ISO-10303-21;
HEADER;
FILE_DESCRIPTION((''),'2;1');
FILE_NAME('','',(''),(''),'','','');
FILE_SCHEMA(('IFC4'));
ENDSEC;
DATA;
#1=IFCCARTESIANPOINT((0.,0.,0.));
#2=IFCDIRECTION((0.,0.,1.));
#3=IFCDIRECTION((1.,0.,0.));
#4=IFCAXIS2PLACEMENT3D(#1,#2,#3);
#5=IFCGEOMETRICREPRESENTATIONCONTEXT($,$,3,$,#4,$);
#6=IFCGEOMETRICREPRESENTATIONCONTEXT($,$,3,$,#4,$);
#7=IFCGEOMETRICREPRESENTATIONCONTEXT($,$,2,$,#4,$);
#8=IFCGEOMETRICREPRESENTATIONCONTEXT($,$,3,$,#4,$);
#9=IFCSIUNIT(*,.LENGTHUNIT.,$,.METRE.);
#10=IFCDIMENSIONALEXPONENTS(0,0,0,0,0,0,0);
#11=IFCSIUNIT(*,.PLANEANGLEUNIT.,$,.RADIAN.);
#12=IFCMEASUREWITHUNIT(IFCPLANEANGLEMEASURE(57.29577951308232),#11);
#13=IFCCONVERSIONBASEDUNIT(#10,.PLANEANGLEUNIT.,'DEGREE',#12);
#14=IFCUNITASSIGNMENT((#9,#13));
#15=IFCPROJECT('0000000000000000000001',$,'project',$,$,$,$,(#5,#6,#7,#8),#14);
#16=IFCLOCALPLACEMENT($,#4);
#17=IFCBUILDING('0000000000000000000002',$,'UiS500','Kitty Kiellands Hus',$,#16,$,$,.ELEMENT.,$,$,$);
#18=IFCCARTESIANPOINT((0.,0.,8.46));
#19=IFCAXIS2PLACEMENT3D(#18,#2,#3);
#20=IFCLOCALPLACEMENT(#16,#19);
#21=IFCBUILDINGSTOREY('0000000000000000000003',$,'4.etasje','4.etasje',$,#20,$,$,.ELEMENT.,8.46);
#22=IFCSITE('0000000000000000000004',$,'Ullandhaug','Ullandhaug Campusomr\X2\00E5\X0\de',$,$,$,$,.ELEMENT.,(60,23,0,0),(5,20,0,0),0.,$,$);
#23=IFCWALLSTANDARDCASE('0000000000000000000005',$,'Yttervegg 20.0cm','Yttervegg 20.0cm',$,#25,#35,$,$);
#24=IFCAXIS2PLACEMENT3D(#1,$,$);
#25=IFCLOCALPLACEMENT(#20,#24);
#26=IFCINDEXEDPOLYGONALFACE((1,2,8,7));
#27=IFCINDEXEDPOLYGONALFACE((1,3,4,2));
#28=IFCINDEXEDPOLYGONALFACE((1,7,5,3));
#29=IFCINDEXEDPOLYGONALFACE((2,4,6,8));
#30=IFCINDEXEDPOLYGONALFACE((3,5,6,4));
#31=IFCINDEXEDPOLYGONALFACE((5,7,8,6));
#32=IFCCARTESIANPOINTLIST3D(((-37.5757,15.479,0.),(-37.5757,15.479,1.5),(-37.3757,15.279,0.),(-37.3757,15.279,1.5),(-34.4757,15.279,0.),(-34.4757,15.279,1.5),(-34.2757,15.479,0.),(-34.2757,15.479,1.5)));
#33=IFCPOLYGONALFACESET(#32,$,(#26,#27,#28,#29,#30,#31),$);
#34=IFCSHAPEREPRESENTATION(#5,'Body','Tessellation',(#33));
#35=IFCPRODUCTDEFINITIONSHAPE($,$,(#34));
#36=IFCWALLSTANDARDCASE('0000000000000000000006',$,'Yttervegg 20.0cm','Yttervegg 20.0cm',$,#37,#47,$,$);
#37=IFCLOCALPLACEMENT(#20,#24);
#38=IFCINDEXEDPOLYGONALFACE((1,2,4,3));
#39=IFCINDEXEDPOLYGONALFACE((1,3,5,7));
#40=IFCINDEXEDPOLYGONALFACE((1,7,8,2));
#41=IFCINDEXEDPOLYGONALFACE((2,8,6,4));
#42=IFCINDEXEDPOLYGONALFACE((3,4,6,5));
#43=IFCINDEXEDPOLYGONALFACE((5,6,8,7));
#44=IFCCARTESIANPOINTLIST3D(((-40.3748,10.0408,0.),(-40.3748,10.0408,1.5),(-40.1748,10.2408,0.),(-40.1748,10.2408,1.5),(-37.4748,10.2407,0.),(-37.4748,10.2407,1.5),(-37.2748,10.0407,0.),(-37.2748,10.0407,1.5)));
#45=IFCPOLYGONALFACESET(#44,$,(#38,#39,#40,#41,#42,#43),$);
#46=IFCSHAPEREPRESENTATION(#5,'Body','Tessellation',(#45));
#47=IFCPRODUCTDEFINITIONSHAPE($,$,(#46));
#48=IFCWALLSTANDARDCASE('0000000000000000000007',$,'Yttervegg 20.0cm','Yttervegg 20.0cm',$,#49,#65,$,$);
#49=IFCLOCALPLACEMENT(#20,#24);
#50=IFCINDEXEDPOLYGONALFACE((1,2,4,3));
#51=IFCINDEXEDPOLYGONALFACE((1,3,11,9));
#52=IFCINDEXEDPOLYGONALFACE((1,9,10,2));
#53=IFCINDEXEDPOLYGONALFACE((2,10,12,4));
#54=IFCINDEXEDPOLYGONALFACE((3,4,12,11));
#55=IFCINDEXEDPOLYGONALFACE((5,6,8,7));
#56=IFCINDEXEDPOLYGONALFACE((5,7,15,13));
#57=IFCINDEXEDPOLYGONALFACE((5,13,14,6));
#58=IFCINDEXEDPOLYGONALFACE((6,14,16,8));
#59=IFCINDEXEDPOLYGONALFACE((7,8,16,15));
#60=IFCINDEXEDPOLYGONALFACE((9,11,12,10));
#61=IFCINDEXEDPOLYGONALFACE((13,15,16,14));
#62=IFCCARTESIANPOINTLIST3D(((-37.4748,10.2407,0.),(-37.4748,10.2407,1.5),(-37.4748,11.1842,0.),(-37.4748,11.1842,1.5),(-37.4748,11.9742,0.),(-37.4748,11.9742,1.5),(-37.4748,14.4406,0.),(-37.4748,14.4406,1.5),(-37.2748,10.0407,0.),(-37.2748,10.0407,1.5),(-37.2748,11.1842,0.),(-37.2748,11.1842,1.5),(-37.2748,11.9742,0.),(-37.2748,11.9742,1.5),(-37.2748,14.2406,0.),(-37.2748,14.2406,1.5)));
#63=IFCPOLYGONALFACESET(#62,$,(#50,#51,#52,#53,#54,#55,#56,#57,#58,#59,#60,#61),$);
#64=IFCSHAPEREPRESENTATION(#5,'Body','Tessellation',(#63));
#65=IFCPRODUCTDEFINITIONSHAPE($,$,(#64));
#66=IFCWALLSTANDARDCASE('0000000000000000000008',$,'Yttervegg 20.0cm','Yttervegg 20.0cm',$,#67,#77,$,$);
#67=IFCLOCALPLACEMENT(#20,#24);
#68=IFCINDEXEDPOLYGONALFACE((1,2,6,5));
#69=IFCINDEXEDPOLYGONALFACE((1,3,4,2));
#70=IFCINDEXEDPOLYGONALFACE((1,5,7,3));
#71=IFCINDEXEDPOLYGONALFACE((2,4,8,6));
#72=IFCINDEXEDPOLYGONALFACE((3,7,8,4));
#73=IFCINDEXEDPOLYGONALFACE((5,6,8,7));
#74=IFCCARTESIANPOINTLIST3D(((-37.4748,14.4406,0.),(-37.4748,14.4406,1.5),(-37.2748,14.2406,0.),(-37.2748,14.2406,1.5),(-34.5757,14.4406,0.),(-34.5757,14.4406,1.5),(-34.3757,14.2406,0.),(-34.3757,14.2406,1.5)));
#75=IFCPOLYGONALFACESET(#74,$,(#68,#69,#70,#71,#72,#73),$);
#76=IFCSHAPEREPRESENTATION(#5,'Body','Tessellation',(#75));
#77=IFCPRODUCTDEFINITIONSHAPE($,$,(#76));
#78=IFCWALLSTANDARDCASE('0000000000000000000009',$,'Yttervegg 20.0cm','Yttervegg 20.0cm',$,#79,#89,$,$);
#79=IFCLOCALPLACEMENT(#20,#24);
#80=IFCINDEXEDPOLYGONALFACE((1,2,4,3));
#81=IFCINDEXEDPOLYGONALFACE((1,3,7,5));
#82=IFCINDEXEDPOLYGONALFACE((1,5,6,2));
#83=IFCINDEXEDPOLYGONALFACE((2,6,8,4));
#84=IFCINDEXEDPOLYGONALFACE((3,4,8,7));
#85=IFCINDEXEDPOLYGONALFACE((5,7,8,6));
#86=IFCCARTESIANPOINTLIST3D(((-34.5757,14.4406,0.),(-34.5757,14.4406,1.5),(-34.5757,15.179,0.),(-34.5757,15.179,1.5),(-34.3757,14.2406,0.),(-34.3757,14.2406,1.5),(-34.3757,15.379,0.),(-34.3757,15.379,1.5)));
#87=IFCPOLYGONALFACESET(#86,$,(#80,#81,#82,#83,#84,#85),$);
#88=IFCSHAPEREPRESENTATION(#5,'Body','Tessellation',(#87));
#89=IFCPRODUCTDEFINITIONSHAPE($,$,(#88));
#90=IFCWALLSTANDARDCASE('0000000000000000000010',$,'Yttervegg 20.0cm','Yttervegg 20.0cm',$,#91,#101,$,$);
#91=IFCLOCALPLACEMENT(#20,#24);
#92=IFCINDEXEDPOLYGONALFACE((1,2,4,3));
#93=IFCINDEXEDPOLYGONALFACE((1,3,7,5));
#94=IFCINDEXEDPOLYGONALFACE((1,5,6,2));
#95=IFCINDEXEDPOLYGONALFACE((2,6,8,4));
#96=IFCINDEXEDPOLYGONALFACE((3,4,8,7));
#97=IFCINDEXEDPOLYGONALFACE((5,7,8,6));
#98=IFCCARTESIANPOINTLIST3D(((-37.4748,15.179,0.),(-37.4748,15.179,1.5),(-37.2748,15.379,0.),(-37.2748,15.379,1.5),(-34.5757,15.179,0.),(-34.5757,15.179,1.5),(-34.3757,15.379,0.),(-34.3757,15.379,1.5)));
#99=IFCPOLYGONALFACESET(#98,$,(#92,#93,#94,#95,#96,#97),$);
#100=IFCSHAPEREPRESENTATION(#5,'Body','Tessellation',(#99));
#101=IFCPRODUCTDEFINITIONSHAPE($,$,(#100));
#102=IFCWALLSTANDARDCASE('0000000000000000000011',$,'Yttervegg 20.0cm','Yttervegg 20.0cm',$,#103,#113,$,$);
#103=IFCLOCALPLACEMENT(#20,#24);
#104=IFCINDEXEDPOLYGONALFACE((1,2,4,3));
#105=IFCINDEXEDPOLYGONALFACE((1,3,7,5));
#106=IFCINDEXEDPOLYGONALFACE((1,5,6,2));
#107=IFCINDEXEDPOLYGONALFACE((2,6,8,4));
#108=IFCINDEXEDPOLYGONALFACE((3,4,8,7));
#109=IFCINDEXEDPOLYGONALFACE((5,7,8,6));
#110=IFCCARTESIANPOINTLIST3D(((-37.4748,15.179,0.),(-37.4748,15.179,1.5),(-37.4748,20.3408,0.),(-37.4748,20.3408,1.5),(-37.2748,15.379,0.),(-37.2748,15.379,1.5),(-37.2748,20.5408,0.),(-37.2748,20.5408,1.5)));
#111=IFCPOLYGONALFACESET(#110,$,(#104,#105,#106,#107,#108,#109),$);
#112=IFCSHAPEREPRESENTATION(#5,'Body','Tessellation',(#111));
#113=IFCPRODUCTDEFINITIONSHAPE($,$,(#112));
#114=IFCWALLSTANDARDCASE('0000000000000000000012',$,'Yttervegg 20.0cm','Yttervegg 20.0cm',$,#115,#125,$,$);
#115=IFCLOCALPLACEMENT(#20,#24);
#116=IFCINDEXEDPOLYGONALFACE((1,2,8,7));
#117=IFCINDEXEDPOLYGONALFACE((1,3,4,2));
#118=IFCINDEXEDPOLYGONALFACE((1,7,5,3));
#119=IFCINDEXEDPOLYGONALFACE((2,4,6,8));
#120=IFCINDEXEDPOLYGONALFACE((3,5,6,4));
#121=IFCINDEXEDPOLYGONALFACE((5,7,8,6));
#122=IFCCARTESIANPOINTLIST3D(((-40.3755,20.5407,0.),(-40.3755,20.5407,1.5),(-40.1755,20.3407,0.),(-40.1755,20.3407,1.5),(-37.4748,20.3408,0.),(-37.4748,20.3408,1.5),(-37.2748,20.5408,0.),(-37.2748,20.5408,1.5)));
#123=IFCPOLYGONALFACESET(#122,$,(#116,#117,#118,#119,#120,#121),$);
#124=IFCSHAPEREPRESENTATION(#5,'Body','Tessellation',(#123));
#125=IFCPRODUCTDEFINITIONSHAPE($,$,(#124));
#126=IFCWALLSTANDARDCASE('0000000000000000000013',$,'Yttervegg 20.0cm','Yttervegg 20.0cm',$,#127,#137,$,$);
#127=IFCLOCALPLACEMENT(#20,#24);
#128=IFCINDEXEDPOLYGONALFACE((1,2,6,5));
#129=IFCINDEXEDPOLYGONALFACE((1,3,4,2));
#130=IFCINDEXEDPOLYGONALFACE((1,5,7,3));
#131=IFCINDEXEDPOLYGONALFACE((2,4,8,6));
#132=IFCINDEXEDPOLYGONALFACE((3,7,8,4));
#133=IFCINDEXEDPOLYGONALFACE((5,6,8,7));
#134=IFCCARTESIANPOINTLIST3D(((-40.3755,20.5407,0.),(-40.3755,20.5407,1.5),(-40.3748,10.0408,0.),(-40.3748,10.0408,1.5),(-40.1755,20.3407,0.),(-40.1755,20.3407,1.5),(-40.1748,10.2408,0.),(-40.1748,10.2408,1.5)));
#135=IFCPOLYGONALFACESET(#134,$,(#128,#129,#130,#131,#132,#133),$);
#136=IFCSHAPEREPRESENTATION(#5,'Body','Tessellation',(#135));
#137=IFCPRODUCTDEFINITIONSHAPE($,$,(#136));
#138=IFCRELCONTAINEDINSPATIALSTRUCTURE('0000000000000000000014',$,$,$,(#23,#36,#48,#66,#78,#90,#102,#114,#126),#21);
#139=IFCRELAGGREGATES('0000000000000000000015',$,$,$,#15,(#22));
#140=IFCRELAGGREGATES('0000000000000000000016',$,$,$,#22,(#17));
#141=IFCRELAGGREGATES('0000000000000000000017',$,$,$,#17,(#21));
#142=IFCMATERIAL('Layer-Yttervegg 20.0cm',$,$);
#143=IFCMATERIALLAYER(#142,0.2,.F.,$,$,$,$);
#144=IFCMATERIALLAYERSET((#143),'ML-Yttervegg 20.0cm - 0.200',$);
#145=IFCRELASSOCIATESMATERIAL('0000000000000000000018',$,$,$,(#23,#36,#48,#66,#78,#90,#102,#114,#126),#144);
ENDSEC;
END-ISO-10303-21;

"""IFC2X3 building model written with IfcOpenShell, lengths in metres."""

from ifc_helpers import new_model, entity, si_unit, converted_unit, frame, origin_with_axes, place, context, project, spatial, polyline, outline, extrude, material, layer, layer_set, layer_usage, element, save


model = new_model("IFC2X3")

# Units and contexts
context_of_model_1 = context(None, 3, world=origin_with_axes())
context_of_model_2 = context(None, 3, world=origin_with_axes())
context_of_model_3 = context(None, 2, world=origin_with_axes())
context_of_model_4 = context(None, 3, world=origin_with_axes())
ifc_project = project(units=[si_unit("LENGTHUNIT", "METRE"), converted_unit("PLANEANGLEUNIT", "DEGREE", entity("IfcPlaneAngleMeasure", 57.29577951308232), si_unit("PLANEANGLEUNIT", "RADIAN"), dimensions=[0, 0, 0, 0, 0, 0, 0])], contexts=[context_of_model_1, context_of_model_2, context_of_model_3, context_of_model_4])

# Site, building, storey
site = spatial("IfcSite", under=ifc_project, Name="Ullandhaug", Description="Ullandhaug Campusområde", CompositionType="ELEMENT", RefLatitude=(60, 23, 0, 0), RefLongitude=(5, 20, 0, 0), RefElevation=0.0)
building_placement = place(None, origin_with_axes())
building = spatial("IfcBuilding", under=site, at=building_placement, Name="UiS500", Description="Kitty Kiellands Hus", CompositionType="ELEMENT")
storey_placement = place(building_placement, frame((0.0, 0.0, 8.46), z_axis=(0.0, 0.0, 1.0), x_axis=(1.0, 0.0, 0.0)))
storey = spatial("IfcBuildingStorey", under=building, at=storey_placement, Name="4.etasje", Description="4.etasje", CompositionType="ELEMENT", Elevation=8.46)

# Walls
ifc_material_1 = material(Name="Layer-Yttervegg 20.0cm")
ifc_layer_1 = layer(ifc_material_1, 0.2, ventilated=False)
ifc_layer_set_1 = layer_set([ifc_layer_1], Name="ML-Yttervegg 20.0cm - 0.200")
ifc_layer_usage_1 = layer_usage(ifc_layer_set_1, "AXIS2", "POSITIVE", 0.0)
wall_1_placement = place(storey_placement, frame((-37.3757, 15.279, 0.0), z_axis=(0.0, 0.0, 1.0), x_axis=(1.0, 0.0, 0.0)))
element("IfcWallStandardCase", 1, at=wall_1_placement, inside=storey, material=ifc_layer_usage_1, Name="Yttervegg 20.0cm", Description="Yttervegg 20.0cm", context=context_of_model_1, shape_type="SweptSolid", body=[
    extrude(outline(polyline([(0.0, 0.0), (2.9, 0.0), (3.1, 0.2), (-0.2, 0.2), (0.0, 0.0)])), origin_with_axes(), (0.0, 0.0, 1.0), 1.5),
])
wall_2_placement = place(storey_placement, frame((-40.3748, 10.0408, 0.0), z_axis=(0.0, 0.0, 1.0), x_axis=(1.0, -0.000034, 0.0)))
element("IfcWallStandardCase", 2, at=wall_2_placement, inside=storey, material=ifc_layer_usage_1, Name="Yttervegg 20.0cm", Description="Yttervegg 20.0cm", context=context_of_model_1, shape_type="SweptSolid", body=[
    extrude(outline(polyline([(0.0, 0.0), (3.1, 0.0), (2.9, 0.2), (0.2, 0.2), (0.0, 0.0)])), frame((0.0, 0.0, 0.0), z_axis=(0.0, 0.0, 1.0), x_axis=(1.0, 0.0, 0.0)), (0.0, 0.0, 1.0), 1.5),
])

# Wall, opening
wall_3_placement = place(storey_placement, frame((-37.2748, 10.0407, 0.0), z_axis=(0.0, 0.0, 1.0), x_axis=(0.0, 1.0, 0.0)))
wall_3 = element("IfcWallStandardCase", 3, at=wall_3_placement, inside=storey, material=ifc_layer_usage_1, Name="Yttervegg 20.0cm", Description="Yttervegg 20.0cm", context=context_of_model_1, shape_type="SweptSolid", body=[
    extrude(outline(polyline([(0.0, 0.0), (4.1998, 0.0), (4.3998, 0.2), (0.2, 0.2), (0.0, 0.0)])), frame((0.0, 0.0, 0.0), z_axis=(0.0, 0.0, 1.0), x_axis=(1.0, 0.0, 0.0)), (0.0, 0.0, 1.0), 1.5),
])
opening_placement = place(wall_3_placement, frame((1.1434, 0.2, 0.0), z_axis=(0.0, 0.0, 1.0), x_axis=(1.0, 0.0, 0.0)))
element("IfcOpeningElement", 4, at=opening_placement, cuts=wall_3, context=context_of_model_1, shape_type="SweptSolid", body=[
    extrude(outline(polyline([(0.0, 0.0), (1.5, 0.0), (1.5, 0.79), (0.0, 0.79), (0.0, 0.0)])), frame((0.0, 0.0, 0.0), z_axis=(0.0, 1.0, 0.0), x_axis=(0.0, 0.0, 1.0)), (0.0, 0.0, -1.0), 0.2),
])

# Walls
wall_4_placement = place(storey_placement, frame((-37.2748, 14.2406, 0.0), z_axis=(0.0, 0.0, 1.0), x_axis=(1.0, 0.0, 0.0)))
element("IfcWallStandardCase", 5, at=wall_4_placement, inside=storey, material=ifc_layer_usage_1, Name="Yttervegg 20.0cm", Description="Yttervegg 20.0cm", context=context_of_model_1, shape_type="SweptSolid", body=[
    extrude(outline(polyline([(0.0, 0.0), (2.8991, 0.0), (2.6991, 0.2), (-0.2, 0.2), (0.0, 0.0)])), origin_with_axes(), (0.0, 0.0, 1.0), 1.5),
])
wall_5_placement = place(storey_placement, frame((-34.3757, 14.2406, 0.0), z_axis=(0.0, 0.0, 1.0), x_axis=(0.0, 1.0, 0.0)))
element("IfcWallStandardCase", 6, at=wall_5_placement, inside=storey, material=ifc_layer_usage_1, Name="Yttervegg 20.0cm", Description="Yttervegg 20.0cm", context=context_of_model_1, shape_type="SweptSolid", body=[
    extrude(outline(polyline([(0.0, 0.0), (1.1384, 0.0), (0.9384, 0.2), (0.2, 0.2), (0.0, 0.0)])), frame((0.0, 0.0, 0.0), z_axis=(0.0, 0.0, 1.0), x_axis=(1.0, 0.0, 0.0)), (0.0, 0.0, 1.0), 1.5),
])
wall_6_placement = place(storey_placement, frame((-34.3757, 15.379, 0.0), z_axis=(0.0, 0.0, 1.0), x_axis=(-1.0, 0.0, 0.0)))
element("IfcWallStandardCase", 7, at=wall_6_placement, inside=storey, material=ifc_layer_usage_1, Name="Yttervegg 20.0cm", Description="Yttervegg 20.0cm", context=context_of_model_1, shape_type="SweptSolid", body=[
    extrude(outline(polyline([(0.0, 0.0), (2.8991, 0.0), (3.0991, 0.2), (0.2, 0.2), (0.0, 0.0)])), frame((0.0, 0.0, 0.0), z_axis=(0.0, 0.0, 1.0), x_axis=(1.0, 0.0, 0.0)), (0.0, 0.0, 1.0), 1.5),
])
wall_7_placement = place(storey_placement, frame((-37.2748, 15.379, 0.0), z_axis=(0.0, 0.0, 1.0), x_axis=(0.0, 1.0, 0.0)))
element("IfcWallStandardCase", 8, at=wall_7_placement, inside=storey, material=ifc_layer_usage_1, Name="Yttervegg 20.0cm", Description="Yttervegg 20.0cm", context=context_of_model_1, shape_type="SweptSolid", body=[
    extrude(outline(polyline([(0.0, 0.0), (5.1619, 0.0), (4.9619, 0.2), (-0.2, 0.2), (0.0, 0.0)])), frame((0.0, 0.0, 0.0), z_axis=(0.0, 0.0, 1.0), x_axis=(1.0, 0.0, 0.0)), (0.0, 0.0, 1.0), 1.5),
])
wall_8_placement = place(storey_placement, frame((-37.2748, 20.5408, 0.0), z_axis=(0.0, 0.0, 1.0), x_axis=(-1.0, -0.00006, 0.0)))
element("IfcWallStandardCase", 9, at=wall_8_placement, inside=storey, material=ifc_layer_usage_1, Name="Yttervegg 20.0cm", Description="Yttervegg 20.0cm", context=context_of_model_1, shape_type="SweptSolid", body=[
    extrude(outline(polyline([(0.0, 0.0), (3.1006, 0.0), (2.9006, 0.2), (0.2, 0.2), (0.0, 0.0)])), frame((0.0, 0.0, 0.0), z_axis=(0.0, 0.0, 1.0), x_axis=(1.0, 0.0, 0.0)), (0.0, 0.0, 1.0), 1.5),
])
wall_9_placement = place(storey_placement, frame((-40.3755, 20.5407, 0.0), z_axis=(0.0, 0.0, 1.0), x_axis=(0.00006, -1.0, 0.0)))
element("IfcWallStandardCase", 10, at=wall_9_placement, inside=storey, material=ifc_layer_usage_1, Name="Yttervegg 20.0cm", Description="Yttervegg 20.0cm", context=context_of_model_1, shape_type="SweptSolid", body=[
    extrude(outline(polyline([(0.0, 0.0), (10.4998, 0.0), (10.2998, 0.2), (0.2, 0.2), (0.0, 0.0)])), frame((0.0, 0.0, 0.0), z_axis=(0.0, 0.0, 1.0), x_axis=(1.0, 0.0, 0.0)), (0.0, 0.0, 1.0), 1.5),
])

save(model, "model.ifc")
